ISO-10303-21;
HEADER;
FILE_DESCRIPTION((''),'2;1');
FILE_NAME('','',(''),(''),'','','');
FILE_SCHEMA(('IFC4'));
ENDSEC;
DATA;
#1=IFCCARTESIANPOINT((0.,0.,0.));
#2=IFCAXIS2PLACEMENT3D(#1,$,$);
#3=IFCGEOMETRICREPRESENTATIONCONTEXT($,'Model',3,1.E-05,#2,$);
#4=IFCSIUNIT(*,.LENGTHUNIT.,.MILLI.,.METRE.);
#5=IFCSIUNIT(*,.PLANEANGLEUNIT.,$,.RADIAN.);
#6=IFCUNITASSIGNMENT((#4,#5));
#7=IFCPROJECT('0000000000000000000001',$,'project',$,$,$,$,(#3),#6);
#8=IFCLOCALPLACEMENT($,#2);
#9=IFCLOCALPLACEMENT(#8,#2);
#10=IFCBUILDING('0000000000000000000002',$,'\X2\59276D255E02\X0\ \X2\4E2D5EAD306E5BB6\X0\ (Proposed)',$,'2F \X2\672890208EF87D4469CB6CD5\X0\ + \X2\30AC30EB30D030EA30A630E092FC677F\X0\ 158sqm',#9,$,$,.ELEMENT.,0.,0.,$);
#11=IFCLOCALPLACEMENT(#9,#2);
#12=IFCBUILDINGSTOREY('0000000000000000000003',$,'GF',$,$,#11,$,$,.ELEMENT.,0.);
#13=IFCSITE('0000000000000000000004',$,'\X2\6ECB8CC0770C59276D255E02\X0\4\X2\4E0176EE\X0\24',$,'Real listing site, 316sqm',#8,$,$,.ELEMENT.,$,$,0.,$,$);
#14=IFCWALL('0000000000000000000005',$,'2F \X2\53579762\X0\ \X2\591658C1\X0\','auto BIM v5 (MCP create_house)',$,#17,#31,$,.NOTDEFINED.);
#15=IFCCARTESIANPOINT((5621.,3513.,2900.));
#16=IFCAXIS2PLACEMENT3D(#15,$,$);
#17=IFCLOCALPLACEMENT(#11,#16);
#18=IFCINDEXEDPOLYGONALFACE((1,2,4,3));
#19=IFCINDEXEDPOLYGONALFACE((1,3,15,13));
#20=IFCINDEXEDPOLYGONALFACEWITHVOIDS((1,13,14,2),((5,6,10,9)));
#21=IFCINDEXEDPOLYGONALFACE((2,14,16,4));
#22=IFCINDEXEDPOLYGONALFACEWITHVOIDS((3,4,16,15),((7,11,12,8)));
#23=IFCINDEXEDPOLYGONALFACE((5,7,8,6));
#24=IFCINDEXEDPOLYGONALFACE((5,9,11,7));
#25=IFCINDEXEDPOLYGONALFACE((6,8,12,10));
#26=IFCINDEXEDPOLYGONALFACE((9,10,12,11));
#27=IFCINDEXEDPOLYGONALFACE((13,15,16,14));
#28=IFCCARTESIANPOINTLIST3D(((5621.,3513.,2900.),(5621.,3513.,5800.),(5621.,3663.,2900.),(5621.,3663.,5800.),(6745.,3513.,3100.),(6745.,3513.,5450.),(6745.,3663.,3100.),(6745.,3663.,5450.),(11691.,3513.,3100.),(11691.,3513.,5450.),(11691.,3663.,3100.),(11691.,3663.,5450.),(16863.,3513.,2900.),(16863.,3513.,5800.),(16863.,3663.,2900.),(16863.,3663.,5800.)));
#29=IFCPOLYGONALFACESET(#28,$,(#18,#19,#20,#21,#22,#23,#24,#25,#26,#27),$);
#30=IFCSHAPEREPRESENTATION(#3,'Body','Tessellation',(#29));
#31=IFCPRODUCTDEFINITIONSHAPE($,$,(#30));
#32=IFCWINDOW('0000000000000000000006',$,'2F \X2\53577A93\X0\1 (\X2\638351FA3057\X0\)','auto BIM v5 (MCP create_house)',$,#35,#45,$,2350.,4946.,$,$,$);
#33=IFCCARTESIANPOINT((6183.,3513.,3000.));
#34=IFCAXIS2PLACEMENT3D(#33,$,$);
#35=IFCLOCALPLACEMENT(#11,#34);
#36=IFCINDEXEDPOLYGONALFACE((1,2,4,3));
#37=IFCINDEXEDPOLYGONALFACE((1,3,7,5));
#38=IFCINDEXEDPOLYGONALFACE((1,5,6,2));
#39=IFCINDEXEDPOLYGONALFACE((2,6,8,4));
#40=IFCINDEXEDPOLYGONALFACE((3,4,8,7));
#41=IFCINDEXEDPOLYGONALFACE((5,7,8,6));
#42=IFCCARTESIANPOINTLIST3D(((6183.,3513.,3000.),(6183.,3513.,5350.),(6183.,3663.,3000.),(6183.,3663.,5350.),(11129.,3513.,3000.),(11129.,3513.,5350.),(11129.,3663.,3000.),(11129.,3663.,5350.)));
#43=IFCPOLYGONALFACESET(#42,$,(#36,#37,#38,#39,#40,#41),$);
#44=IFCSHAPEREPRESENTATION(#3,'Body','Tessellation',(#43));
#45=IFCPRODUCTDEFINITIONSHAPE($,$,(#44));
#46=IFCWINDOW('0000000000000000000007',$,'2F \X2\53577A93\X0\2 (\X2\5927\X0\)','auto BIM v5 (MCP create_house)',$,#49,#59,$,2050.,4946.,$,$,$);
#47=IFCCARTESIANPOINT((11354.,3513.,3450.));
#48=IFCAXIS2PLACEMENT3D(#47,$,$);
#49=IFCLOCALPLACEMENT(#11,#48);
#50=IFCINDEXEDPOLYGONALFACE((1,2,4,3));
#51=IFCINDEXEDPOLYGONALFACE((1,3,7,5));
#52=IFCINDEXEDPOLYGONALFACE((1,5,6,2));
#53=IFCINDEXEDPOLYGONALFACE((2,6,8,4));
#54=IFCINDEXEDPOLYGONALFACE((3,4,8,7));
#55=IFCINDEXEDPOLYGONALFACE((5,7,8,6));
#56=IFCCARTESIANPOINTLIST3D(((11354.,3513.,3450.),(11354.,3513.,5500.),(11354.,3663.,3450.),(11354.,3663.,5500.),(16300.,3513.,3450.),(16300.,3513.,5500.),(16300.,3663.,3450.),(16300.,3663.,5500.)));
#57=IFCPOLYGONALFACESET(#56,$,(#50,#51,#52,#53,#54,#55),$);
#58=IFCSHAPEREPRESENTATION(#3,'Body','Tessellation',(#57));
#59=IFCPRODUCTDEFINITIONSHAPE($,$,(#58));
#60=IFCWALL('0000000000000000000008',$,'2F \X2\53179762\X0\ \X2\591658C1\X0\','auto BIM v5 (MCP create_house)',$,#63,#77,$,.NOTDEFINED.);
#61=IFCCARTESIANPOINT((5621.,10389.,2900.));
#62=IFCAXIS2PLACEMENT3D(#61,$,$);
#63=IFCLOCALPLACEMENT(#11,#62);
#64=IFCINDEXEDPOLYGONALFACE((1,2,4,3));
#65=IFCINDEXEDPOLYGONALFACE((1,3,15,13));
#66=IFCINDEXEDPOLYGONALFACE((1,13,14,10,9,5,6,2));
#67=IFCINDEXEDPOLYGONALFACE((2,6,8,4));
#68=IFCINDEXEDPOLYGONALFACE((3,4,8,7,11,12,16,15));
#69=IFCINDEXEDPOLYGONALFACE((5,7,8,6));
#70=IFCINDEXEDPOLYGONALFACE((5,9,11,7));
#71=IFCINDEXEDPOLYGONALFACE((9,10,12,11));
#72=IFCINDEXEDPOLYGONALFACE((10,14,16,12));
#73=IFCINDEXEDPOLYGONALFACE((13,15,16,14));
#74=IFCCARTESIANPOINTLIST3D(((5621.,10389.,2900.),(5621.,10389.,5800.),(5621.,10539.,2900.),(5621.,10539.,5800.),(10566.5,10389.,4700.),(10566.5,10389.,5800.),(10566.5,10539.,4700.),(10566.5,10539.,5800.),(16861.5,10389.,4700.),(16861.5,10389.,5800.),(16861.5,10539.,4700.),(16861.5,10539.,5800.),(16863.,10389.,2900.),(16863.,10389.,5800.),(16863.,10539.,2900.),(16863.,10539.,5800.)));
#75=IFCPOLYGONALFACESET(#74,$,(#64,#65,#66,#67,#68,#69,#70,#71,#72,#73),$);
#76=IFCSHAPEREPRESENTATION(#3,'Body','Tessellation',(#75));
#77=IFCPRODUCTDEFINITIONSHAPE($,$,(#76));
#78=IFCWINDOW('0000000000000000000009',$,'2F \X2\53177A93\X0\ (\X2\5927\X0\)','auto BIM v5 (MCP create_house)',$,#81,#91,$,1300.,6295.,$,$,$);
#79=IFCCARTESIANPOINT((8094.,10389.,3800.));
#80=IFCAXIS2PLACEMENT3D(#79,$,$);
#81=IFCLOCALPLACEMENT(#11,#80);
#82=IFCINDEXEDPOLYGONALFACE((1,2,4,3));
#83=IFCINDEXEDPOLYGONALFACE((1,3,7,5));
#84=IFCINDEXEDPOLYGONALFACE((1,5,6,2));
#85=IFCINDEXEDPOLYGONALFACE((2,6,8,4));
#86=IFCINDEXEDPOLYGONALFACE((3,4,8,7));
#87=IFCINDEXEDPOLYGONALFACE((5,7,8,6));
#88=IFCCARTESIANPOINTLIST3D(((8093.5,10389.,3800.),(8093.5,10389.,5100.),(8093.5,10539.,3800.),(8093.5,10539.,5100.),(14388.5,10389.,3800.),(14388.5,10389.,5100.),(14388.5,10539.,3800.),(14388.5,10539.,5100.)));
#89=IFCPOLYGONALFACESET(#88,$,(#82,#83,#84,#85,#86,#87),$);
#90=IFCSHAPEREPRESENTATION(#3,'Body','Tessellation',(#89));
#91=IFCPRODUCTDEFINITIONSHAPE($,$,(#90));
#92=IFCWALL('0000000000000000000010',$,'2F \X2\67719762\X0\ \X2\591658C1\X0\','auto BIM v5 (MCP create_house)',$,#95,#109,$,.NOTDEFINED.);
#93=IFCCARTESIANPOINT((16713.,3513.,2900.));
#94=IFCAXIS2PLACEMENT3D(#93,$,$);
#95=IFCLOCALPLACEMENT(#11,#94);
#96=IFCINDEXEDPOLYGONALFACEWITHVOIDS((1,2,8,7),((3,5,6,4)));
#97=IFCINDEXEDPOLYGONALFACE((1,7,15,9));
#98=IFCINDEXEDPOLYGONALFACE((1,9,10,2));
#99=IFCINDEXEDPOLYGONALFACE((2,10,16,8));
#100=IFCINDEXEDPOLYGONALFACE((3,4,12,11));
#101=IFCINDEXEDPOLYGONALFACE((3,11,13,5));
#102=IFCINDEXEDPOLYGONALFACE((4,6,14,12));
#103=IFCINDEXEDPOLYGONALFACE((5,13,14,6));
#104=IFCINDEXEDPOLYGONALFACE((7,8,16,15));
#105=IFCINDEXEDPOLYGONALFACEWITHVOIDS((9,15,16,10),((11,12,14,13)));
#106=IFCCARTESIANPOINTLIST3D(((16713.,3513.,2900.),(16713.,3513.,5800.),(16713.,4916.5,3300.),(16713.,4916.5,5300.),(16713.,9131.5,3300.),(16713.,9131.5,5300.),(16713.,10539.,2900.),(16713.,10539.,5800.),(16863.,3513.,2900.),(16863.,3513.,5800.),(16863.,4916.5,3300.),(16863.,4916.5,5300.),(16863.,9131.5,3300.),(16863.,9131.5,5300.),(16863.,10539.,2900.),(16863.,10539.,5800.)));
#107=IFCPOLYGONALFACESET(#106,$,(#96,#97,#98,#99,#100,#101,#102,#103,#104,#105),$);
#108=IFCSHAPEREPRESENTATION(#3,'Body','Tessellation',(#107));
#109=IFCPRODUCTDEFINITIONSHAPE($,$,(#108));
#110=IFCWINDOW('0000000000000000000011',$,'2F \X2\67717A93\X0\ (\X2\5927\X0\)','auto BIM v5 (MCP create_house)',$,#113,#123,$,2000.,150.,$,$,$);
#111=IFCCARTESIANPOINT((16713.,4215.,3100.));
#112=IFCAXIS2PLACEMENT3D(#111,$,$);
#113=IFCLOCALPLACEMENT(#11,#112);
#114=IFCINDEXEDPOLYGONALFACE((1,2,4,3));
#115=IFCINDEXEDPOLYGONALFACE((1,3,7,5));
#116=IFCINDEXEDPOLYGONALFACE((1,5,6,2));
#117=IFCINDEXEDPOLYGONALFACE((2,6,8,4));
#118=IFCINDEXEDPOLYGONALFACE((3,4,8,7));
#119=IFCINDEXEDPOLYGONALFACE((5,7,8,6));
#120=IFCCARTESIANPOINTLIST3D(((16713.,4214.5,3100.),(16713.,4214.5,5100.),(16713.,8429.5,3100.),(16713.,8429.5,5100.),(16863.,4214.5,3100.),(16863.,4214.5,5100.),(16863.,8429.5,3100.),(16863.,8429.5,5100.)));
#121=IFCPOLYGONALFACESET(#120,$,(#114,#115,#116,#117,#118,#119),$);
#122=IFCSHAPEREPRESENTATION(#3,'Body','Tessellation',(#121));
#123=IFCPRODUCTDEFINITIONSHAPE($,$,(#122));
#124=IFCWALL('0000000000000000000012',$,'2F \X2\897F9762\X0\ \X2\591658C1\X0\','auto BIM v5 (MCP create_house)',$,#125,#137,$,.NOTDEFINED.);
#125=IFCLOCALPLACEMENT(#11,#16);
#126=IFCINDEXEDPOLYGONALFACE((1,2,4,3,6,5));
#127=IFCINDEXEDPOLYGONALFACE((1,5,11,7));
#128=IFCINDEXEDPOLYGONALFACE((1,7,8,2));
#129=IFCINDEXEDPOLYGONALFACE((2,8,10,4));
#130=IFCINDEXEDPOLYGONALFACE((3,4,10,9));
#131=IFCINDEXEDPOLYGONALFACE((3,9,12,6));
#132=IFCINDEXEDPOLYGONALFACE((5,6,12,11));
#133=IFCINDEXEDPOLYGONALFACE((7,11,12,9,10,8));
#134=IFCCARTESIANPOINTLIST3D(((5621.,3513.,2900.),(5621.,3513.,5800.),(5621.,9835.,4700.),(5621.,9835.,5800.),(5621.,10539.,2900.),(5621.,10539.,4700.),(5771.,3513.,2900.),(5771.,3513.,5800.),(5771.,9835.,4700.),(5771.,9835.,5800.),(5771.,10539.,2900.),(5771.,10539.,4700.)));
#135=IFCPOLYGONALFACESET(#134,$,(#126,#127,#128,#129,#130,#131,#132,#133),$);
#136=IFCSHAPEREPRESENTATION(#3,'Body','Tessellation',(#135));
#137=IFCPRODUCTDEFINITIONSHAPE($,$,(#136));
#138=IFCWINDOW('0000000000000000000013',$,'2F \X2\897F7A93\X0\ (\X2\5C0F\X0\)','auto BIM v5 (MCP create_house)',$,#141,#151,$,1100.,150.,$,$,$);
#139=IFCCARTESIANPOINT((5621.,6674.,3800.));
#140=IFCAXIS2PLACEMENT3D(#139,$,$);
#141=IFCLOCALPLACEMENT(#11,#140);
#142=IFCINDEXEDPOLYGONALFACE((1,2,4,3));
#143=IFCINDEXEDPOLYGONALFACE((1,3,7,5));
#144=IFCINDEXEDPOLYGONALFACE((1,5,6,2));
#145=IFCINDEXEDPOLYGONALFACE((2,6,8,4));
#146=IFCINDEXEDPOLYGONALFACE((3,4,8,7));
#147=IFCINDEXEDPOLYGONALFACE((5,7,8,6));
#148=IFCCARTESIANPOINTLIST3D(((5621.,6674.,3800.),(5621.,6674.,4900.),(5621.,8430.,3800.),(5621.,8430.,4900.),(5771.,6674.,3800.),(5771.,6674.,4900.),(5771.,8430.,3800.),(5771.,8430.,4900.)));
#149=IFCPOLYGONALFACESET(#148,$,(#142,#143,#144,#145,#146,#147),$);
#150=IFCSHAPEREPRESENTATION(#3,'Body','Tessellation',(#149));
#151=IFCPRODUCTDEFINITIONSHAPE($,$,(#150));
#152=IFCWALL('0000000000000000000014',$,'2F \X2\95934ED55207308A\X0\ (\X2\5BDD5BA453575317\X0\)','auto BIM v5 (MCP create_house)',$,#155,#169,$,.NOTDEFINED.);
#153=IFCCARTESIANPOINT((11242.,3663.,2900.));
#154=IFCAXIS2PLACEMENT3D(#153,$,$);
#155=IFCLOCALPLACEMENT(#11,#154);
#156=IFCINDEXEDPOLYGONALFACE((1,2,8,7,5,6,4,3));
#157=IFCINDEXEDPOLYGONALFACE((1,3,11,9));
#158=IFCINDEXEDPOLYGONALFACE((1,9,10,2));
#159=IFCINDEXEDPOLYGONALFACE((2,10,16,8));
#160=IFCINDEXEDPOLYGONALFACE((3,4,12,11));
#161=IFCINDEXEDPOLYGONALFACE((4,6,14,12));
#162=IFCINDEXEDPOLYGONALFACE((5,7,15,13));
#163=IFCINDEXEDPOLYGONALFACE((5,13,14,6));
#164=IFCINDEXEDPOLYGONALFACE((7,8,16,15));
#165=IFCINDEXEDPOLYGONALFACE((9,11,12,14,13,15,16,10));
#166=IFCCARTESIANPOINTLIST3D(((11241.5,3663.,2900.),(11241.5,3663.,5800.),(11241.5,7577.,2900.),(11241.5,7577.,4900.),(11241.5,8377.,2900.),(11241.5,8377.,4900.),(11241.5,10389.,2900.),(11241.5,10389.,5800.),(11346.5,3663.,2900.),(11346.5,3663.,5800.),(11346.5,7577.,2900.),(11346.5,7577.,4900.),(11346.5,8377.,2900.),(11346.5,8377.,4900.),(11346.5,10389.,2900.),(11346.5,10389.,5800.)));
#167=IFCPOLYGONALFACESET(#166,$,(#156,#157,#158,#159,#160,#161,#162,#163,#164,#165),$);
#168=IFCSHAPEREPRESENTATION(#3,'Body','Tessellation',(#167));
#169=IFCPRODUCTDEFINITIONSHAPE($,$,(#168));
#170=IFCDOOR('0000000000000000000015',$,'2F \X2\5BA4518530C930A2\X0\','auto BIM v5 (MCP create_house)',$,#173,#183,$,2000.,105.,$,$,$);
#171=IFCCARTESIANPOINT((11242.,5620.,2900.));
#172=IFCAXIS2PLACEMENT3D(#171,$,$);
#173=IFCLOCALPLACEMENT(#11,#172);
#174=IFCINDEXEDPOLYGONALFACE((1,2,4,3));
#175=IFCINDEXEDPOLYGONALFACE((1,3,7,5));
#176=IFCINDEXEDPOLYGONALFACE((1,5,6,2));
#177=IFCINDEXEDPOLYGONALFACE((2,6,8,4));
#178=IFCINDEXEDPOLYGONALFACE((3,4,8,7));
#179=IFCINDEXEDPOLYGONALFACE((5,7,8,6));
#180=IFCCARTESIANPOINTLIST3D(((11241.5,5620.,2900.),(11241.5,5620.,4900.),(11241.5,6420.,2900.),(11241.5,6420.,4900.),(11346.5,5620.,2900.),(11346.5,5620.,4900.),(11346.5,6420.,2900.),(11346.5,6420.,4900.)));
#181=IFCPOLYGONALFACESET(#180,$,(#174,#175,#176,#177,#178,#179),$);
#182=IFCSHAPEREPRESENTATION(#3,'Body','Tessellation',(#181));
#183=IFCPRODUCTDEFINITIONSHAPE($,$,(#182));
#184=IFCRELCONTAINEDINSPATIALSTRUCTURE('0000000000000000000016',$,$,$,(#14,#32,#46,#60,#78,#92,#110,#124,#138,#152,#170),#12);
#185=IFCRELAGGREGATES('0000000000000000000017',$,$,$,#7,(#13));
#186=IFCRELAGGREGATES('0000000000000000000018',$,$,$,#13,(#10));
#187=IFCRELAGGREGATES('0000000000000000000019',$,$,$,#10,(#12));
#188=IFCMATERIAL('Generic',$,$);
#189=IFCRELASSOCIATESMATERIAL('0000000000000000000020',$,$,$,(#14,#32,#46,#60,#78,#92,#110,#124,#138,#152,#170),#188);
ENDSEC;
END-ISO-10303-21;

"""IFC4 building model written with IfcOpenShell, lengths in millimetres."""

from ifc_helpers import new_model, si_unit, frame, frame_2d, origin, place, context, project, spatial, rectangle, extrude, material, element, fill, save


model = new_model("IFC4")

# Units and contexts
model_context = context("Model", 3, precision=1e-05, world=origin())
ifc_project = project(units=[si_unit("LENGTHUNIT", "METRE", prefix="MILLI"), si_unit("PLANEANGLEUNIT", "RADIAN")], contexts=[model_context])

# Site, building, storey
site_placement = place(None, origin())
site = spatial("IfcSite", under=ifc_project, at=site_placement, Name="滋賀県大津市4丁目24", ObjectType="Real listing site, 316sqm", CompositionType="ELEMENT", RefElevation=0.0)
building_placement = place(site_placement, origin())
building = spatial("IfcBuilding", under=site, at=building_placement, Name="大津市 中庭の家 (Proposed)", ObjectType="2F 木造軸組構法 + ガルバリウム鋼板 158sqm", CompositionType="ELEMENT", ElevationOfRefHeight=0.0, ElevationOfTerrain=0.0)
storey_placement = place(building_placement, origin())
storey = spatial("IfcBuildingStorey", under=building, at=storey_placement, Name="GF", CompositionType="ELEMENT", Elevation=0.0)

# Shared definitions
ifc_material = material(Name="Generic")

# Wall, openings, windows
wall_1_placement = place(storey_placement, frame((5621.0, 3513.0, 2900.0)))
wall_1 = element("IfcWall", 1, at=wall_1_placement, inside=storey, material=ifc_material, Name="2F 南面 外壁", Description="auto BIM v5 (MCP create_house)", PredefinedType="NOTDEFINED", context=model_context, shape_type="SweptSolid", body=[
    extrude(rectangle(XDim=11242.0, YDim=150.0, at=frame_2d((5621.0, 75.0))), frame((5621.0, 3513.0, 2900.0)), (0.0, 0.0, 1.0), 2900.0),
])
opening_1_placement = place(storey_placement, frame((6183.0, 3513.0, 3000.0)))
opening_1 = element("IfcOpeningElement", 2, at=opening_1_placement, cuts=wall_1, PredefinedType="NOTDEFINED", context=model_context, shape_type="SweptSolid", body=[
    extrude(rectangle(XDim=4946.0, YDim=150.0, at=frame_2d((2473.0, 75.0))), frame((6183.0, 3513.0, 3000.0)), (0.0, 0.0, 1.0), 2350.0),
])
opening_2_placement = place(storey_placement, frame((11354.0, 3513.0, 3450.0)))
opening_2 = element("IfcOpeningElement", 3, at=opening_2_placement, cuts=wall_1, PredefinedType="NOTDEFINED", context=model_context, shape_type="SweptSolid", body=[
    extrude(rectangle(XDim=4946.0, YDim=150.0, at=frame_2d((2473.0, 75.0))), frame((11354.0, 3513.0, 3450.0)), (0.0, 0.0, 1.0), 2050.0),
])
window_1_placement = place(storey_placement, frame((6183.0, 3513.0, 3000.0)))
window_1 = element("IfcWindow", 4, at=window_1_placement, inside=storey, material=ifc_material, Name="2F 南窓1 (掃出し)", Description="auto BIM v5 (MCP create_house)", OverallHeight=2350.0, OverallWidth=4946.0, context=model_context, shape_type="SweptSolid", body=[
    extrude(rectangle(XDim=4946.0, YDim=150.0, at=frame_2d((2473.0, 75.0))), frame((6183.0, 3513.0, 3000.0)), (0.0, 0.0, 1.0), 2350.0),
])
fill(opening_1, window_1)
window_2_placement = place(storey_placement, frame((11354.0, 3513.0, 3450.0)))
window_2 = element("IfcWindow", 5, at=window_2_placement, inside=storey, material=ifc_material, Name="2F 南窓2 (大)", Description="auto BIM v5 (MCP create_house)", OverallHeight=2050.0, OverallWidth=4946.0, context=model_context, shape_type="SweptSolid", body=[
    extrude(rectangle(XDim=4946.0, YDim=150.0, at=frame_2d((2473.0, 75.0))), frame((11354.0, 3513.0, 3450.0)), (0.0, 0.0, 1.0), 2050.0),
])
fill(opening_2, window_2)

# Walls, openings, windows
wall_2_placement = place(storey_placement, frame((5621.0, 10389.0, 2900.0)))
wall_2 = element("IfcWall", 6, at=wall_2_placement, inside=storey, material=ifc_material, Name="2F 北面 外壁", Description="auto BIM v5 (MCP create_house)", PredefinedType="NOTDEFINED", context=model_context, shape_type="SweptSolid", body=[
    extrude(rectangle(XDim=11242.0, YDim=150.0, at=frame_2d((5621.0, 75.0))), frame((5621.0, 10389.0, 2900.0)), (0.0, 0.0, 1.0), 2900.0),
])
opening_3_placement = place(storey_placement, frame((8094.0, 10389.0, 3800.0)))
opening_3 = element("IfcOpeningElement", 7, at=opening_3_placement, cuts=wall_2, PredefinedType="NOTDEFINED", context=model_context, shape_type="SweptSolid", body=[
    extrude(rectangle(XDim=6295.0, YDim=150.0, at=frame_2d((3147.0, 75.0))), frame((8094.0, 10389.0, 3800.0)), (0.0, 0.0, 1.0), 1300.0),
])
window_3_placement = place(storey_placement, frame((8094.0, 10389.0, 3800.0)))
window_3 = element("IfcWindow", 8, at=window_3_placement, inside=storey, material=ifc_material, Name="2F 北窓 (大)", Description="auto BIM v5 (MCP create_house)", OverallHeight=1300.0, OverallWidth=6295.0, context=model_context, shape_type="SweptSolid", body=[
    extrude(rectangle(XDim=6295.0, YDim=150.0, at=frame_2d((3147.0, 75.0))), frame((8094.0, 10389.0, 3800.0)), (0.0, 0.0, 1.0), 1300.0),
])
fill(opening_3, window_3)
wall_3_placement = place(storey_placement, frame((16713.0, 3513.0, 2900.0)))
wall_3 = element("IfcWall", 9, at=wall_3_placement, inside=storey, material=ifc_material, Name="2F 東面 外壁", Description="auto BIM v5 (MCP create_house)", PredefinedType="NOTDEFINED", context=model_context, shape_type="SweptSolid", body=[
    extrude(rectangle(XDim=150.0, YDim=7026.0, at=frame_2d((75.0, 3513.0))), frame((16713.0, 3513.0, 2900.0)), (0.0, 0.0, 1.0), 2900.0),
])
opening_4_placement = place(storey_placement, frame((16713.0, 4215.0, 3100.0)))
opening_4 = element("IfcOpeningElement", 10, at=opening_4_placement, cuts=wall_3, PredefinedType="NOTDEFINED", context=model_context, shape_type="SweptSolid", body=[
    extrude(rectangle(XDim=150.0, YDim=4215.0, at=frame_2d((75.0, 2107.0))), frame((16713.0, 4215.0, 3100.0)), (0.0, 0.0, 1.0), 2000.0),
])
window_4_placement = place(storey_placement, frame((16713.0, 4215.0, 3100.0)))
window_4 = element("IfcWindow", 11, at=window_4_placement, inside=storey, material=ifc_material, Name="2F 東窓 (大)", Description="auto BIM v5 (MCP create_house)", OverallHeight=2000.0, OverallWidth=150.0, context=model_context, shape_type="SweptSolid", body=[
    extrude(rectangle(XDim=150.0, YDim=4215.0, at=frame_2d((75.0, 2107.0))), frame((16713.0, 4215.0, 3100.0)), (0.0, 0.0, 1.0), 2000.0),
])
fill(opening_4, window_4)
wall_4_placement = place(storey_placement, frame((5621.0, 3513.0, 2900.0)))
wall_4 = element("IfcWall", 12, at=wall_4_placement, inside=storey, material=ifc_material, Name="2F 西面 外壁", Description="auto BIM v5 (MCP create_house)", PredefinedType="NOTDEFINED", context=model_context, shape_type="SweptSolid", body=[
    extrude(rectangle(XDim=150.0, YDim=7026.0, at=frame_2d((75.0, 3513.0))), frame((5621.0, 3513.0, 2900.0)), (0.0, 0.0, 1.0), 2900.0),
])
opening_5_placement = place(storey_placement, frame((5621.0, 6674.0, 3800.0)))
opening_5 = element("IfcOpeningElement", 13, at=opening_5_placement, cuts=wall_4, PredefinedType="NOTDEFINED", context=model_context, shape_type="SweptSolid", body=[
    extrude(rectangle(XDim=150.0, YDim=1756.0, at=frame_2d((75.0, 878.0))), frame((5621.0, 6674.0, 3800.0)), (0.0, 0.0, 1.0), 1100.0),
])
window_5_placement = place(storey_placement, frame((5621.0, 6674.0, 3800.0)))
window_5 = element("IfcWindow", 14, at=window_5_placement, inside=storey, material=ifc_material, Name="2F 西窓 (小)", Description="auto BIM v5 (MCP create_house)", OverallHeight=1100.0, OverallWidth=150.0, context=model_context, shape_type="SweptSolid", body=[
    extrude(rectangle(XDim=150.0, YDim=1756.0, at=frame_2d((75.0, 878.0))), frame((5621.0, 6674.0, 3800.0)), (0.0, 0.0, 1.0), 1100.0),
])
fill(opening_5, window_5)

# Wall, opening, door
wall_5_placement = place(storey_placement, frame((11242.0, 3663.0, 2900.0)))
wall_5 = element("IfcWall", 15, at=wall_5_placement, inside=storey, material=ifc_material, Name="2F 間仕切り (寝室南北)", Description="auto BIM v5 (MCP create_house)", PredefinedType="NOTDEFINED", context=model_context, shape_type="SweptSolid", body=[
    extrude(rectangle(XDim=105.0, YDim=6726.0, at=frame_2d((52.0, 3363.0))), frame((11242.0, 3663.0, 2900.0)), (0.0, 0.0, 1.0), 2900.0),
])
opening_6_placement = place(storey_placement, frame((11242.0, 5620.0, 2900.0)))
opening_6 = element("IfcOpeningElement", 16, at=opening_6_placement, cuts=wall_5, PredefinedType="NOTDEFINED", context=model_context, shape_type="SweptSolid", body=[
    extrude(rectangle(XDim=105.0, YDim=800.0, at=frame_2d((52.0, 400.0))), frame((11242.0, 5620.0, 2900.0)), (0.0, 0.0, 1.0), 2000.0),
])
door_1_placement = place(storey_placement, frame((11242.0, 5620.0, 2900.0)))
door_1 = element("IfcDoor", 17, at=door_1_placement, inside=storey, material=ifc_material, Name="2F 室内ドア", Description="auto BIM v5 (MCP create_house)", OverallHeight=2000.0, OverallWidth=105.0, context=model_context, shape_type="SweptSolid", body=[
    extrude(rectangle(XDim=105.0, YDim=800.0, at=frame_2d((52.0, 400.0))), frame((11242.0, 5620.0, 2900.0)), (0.0, 0.0, 1.0), 2000.0),
])
fill(opening_6, door_1)

save(model, "model.ifc")
